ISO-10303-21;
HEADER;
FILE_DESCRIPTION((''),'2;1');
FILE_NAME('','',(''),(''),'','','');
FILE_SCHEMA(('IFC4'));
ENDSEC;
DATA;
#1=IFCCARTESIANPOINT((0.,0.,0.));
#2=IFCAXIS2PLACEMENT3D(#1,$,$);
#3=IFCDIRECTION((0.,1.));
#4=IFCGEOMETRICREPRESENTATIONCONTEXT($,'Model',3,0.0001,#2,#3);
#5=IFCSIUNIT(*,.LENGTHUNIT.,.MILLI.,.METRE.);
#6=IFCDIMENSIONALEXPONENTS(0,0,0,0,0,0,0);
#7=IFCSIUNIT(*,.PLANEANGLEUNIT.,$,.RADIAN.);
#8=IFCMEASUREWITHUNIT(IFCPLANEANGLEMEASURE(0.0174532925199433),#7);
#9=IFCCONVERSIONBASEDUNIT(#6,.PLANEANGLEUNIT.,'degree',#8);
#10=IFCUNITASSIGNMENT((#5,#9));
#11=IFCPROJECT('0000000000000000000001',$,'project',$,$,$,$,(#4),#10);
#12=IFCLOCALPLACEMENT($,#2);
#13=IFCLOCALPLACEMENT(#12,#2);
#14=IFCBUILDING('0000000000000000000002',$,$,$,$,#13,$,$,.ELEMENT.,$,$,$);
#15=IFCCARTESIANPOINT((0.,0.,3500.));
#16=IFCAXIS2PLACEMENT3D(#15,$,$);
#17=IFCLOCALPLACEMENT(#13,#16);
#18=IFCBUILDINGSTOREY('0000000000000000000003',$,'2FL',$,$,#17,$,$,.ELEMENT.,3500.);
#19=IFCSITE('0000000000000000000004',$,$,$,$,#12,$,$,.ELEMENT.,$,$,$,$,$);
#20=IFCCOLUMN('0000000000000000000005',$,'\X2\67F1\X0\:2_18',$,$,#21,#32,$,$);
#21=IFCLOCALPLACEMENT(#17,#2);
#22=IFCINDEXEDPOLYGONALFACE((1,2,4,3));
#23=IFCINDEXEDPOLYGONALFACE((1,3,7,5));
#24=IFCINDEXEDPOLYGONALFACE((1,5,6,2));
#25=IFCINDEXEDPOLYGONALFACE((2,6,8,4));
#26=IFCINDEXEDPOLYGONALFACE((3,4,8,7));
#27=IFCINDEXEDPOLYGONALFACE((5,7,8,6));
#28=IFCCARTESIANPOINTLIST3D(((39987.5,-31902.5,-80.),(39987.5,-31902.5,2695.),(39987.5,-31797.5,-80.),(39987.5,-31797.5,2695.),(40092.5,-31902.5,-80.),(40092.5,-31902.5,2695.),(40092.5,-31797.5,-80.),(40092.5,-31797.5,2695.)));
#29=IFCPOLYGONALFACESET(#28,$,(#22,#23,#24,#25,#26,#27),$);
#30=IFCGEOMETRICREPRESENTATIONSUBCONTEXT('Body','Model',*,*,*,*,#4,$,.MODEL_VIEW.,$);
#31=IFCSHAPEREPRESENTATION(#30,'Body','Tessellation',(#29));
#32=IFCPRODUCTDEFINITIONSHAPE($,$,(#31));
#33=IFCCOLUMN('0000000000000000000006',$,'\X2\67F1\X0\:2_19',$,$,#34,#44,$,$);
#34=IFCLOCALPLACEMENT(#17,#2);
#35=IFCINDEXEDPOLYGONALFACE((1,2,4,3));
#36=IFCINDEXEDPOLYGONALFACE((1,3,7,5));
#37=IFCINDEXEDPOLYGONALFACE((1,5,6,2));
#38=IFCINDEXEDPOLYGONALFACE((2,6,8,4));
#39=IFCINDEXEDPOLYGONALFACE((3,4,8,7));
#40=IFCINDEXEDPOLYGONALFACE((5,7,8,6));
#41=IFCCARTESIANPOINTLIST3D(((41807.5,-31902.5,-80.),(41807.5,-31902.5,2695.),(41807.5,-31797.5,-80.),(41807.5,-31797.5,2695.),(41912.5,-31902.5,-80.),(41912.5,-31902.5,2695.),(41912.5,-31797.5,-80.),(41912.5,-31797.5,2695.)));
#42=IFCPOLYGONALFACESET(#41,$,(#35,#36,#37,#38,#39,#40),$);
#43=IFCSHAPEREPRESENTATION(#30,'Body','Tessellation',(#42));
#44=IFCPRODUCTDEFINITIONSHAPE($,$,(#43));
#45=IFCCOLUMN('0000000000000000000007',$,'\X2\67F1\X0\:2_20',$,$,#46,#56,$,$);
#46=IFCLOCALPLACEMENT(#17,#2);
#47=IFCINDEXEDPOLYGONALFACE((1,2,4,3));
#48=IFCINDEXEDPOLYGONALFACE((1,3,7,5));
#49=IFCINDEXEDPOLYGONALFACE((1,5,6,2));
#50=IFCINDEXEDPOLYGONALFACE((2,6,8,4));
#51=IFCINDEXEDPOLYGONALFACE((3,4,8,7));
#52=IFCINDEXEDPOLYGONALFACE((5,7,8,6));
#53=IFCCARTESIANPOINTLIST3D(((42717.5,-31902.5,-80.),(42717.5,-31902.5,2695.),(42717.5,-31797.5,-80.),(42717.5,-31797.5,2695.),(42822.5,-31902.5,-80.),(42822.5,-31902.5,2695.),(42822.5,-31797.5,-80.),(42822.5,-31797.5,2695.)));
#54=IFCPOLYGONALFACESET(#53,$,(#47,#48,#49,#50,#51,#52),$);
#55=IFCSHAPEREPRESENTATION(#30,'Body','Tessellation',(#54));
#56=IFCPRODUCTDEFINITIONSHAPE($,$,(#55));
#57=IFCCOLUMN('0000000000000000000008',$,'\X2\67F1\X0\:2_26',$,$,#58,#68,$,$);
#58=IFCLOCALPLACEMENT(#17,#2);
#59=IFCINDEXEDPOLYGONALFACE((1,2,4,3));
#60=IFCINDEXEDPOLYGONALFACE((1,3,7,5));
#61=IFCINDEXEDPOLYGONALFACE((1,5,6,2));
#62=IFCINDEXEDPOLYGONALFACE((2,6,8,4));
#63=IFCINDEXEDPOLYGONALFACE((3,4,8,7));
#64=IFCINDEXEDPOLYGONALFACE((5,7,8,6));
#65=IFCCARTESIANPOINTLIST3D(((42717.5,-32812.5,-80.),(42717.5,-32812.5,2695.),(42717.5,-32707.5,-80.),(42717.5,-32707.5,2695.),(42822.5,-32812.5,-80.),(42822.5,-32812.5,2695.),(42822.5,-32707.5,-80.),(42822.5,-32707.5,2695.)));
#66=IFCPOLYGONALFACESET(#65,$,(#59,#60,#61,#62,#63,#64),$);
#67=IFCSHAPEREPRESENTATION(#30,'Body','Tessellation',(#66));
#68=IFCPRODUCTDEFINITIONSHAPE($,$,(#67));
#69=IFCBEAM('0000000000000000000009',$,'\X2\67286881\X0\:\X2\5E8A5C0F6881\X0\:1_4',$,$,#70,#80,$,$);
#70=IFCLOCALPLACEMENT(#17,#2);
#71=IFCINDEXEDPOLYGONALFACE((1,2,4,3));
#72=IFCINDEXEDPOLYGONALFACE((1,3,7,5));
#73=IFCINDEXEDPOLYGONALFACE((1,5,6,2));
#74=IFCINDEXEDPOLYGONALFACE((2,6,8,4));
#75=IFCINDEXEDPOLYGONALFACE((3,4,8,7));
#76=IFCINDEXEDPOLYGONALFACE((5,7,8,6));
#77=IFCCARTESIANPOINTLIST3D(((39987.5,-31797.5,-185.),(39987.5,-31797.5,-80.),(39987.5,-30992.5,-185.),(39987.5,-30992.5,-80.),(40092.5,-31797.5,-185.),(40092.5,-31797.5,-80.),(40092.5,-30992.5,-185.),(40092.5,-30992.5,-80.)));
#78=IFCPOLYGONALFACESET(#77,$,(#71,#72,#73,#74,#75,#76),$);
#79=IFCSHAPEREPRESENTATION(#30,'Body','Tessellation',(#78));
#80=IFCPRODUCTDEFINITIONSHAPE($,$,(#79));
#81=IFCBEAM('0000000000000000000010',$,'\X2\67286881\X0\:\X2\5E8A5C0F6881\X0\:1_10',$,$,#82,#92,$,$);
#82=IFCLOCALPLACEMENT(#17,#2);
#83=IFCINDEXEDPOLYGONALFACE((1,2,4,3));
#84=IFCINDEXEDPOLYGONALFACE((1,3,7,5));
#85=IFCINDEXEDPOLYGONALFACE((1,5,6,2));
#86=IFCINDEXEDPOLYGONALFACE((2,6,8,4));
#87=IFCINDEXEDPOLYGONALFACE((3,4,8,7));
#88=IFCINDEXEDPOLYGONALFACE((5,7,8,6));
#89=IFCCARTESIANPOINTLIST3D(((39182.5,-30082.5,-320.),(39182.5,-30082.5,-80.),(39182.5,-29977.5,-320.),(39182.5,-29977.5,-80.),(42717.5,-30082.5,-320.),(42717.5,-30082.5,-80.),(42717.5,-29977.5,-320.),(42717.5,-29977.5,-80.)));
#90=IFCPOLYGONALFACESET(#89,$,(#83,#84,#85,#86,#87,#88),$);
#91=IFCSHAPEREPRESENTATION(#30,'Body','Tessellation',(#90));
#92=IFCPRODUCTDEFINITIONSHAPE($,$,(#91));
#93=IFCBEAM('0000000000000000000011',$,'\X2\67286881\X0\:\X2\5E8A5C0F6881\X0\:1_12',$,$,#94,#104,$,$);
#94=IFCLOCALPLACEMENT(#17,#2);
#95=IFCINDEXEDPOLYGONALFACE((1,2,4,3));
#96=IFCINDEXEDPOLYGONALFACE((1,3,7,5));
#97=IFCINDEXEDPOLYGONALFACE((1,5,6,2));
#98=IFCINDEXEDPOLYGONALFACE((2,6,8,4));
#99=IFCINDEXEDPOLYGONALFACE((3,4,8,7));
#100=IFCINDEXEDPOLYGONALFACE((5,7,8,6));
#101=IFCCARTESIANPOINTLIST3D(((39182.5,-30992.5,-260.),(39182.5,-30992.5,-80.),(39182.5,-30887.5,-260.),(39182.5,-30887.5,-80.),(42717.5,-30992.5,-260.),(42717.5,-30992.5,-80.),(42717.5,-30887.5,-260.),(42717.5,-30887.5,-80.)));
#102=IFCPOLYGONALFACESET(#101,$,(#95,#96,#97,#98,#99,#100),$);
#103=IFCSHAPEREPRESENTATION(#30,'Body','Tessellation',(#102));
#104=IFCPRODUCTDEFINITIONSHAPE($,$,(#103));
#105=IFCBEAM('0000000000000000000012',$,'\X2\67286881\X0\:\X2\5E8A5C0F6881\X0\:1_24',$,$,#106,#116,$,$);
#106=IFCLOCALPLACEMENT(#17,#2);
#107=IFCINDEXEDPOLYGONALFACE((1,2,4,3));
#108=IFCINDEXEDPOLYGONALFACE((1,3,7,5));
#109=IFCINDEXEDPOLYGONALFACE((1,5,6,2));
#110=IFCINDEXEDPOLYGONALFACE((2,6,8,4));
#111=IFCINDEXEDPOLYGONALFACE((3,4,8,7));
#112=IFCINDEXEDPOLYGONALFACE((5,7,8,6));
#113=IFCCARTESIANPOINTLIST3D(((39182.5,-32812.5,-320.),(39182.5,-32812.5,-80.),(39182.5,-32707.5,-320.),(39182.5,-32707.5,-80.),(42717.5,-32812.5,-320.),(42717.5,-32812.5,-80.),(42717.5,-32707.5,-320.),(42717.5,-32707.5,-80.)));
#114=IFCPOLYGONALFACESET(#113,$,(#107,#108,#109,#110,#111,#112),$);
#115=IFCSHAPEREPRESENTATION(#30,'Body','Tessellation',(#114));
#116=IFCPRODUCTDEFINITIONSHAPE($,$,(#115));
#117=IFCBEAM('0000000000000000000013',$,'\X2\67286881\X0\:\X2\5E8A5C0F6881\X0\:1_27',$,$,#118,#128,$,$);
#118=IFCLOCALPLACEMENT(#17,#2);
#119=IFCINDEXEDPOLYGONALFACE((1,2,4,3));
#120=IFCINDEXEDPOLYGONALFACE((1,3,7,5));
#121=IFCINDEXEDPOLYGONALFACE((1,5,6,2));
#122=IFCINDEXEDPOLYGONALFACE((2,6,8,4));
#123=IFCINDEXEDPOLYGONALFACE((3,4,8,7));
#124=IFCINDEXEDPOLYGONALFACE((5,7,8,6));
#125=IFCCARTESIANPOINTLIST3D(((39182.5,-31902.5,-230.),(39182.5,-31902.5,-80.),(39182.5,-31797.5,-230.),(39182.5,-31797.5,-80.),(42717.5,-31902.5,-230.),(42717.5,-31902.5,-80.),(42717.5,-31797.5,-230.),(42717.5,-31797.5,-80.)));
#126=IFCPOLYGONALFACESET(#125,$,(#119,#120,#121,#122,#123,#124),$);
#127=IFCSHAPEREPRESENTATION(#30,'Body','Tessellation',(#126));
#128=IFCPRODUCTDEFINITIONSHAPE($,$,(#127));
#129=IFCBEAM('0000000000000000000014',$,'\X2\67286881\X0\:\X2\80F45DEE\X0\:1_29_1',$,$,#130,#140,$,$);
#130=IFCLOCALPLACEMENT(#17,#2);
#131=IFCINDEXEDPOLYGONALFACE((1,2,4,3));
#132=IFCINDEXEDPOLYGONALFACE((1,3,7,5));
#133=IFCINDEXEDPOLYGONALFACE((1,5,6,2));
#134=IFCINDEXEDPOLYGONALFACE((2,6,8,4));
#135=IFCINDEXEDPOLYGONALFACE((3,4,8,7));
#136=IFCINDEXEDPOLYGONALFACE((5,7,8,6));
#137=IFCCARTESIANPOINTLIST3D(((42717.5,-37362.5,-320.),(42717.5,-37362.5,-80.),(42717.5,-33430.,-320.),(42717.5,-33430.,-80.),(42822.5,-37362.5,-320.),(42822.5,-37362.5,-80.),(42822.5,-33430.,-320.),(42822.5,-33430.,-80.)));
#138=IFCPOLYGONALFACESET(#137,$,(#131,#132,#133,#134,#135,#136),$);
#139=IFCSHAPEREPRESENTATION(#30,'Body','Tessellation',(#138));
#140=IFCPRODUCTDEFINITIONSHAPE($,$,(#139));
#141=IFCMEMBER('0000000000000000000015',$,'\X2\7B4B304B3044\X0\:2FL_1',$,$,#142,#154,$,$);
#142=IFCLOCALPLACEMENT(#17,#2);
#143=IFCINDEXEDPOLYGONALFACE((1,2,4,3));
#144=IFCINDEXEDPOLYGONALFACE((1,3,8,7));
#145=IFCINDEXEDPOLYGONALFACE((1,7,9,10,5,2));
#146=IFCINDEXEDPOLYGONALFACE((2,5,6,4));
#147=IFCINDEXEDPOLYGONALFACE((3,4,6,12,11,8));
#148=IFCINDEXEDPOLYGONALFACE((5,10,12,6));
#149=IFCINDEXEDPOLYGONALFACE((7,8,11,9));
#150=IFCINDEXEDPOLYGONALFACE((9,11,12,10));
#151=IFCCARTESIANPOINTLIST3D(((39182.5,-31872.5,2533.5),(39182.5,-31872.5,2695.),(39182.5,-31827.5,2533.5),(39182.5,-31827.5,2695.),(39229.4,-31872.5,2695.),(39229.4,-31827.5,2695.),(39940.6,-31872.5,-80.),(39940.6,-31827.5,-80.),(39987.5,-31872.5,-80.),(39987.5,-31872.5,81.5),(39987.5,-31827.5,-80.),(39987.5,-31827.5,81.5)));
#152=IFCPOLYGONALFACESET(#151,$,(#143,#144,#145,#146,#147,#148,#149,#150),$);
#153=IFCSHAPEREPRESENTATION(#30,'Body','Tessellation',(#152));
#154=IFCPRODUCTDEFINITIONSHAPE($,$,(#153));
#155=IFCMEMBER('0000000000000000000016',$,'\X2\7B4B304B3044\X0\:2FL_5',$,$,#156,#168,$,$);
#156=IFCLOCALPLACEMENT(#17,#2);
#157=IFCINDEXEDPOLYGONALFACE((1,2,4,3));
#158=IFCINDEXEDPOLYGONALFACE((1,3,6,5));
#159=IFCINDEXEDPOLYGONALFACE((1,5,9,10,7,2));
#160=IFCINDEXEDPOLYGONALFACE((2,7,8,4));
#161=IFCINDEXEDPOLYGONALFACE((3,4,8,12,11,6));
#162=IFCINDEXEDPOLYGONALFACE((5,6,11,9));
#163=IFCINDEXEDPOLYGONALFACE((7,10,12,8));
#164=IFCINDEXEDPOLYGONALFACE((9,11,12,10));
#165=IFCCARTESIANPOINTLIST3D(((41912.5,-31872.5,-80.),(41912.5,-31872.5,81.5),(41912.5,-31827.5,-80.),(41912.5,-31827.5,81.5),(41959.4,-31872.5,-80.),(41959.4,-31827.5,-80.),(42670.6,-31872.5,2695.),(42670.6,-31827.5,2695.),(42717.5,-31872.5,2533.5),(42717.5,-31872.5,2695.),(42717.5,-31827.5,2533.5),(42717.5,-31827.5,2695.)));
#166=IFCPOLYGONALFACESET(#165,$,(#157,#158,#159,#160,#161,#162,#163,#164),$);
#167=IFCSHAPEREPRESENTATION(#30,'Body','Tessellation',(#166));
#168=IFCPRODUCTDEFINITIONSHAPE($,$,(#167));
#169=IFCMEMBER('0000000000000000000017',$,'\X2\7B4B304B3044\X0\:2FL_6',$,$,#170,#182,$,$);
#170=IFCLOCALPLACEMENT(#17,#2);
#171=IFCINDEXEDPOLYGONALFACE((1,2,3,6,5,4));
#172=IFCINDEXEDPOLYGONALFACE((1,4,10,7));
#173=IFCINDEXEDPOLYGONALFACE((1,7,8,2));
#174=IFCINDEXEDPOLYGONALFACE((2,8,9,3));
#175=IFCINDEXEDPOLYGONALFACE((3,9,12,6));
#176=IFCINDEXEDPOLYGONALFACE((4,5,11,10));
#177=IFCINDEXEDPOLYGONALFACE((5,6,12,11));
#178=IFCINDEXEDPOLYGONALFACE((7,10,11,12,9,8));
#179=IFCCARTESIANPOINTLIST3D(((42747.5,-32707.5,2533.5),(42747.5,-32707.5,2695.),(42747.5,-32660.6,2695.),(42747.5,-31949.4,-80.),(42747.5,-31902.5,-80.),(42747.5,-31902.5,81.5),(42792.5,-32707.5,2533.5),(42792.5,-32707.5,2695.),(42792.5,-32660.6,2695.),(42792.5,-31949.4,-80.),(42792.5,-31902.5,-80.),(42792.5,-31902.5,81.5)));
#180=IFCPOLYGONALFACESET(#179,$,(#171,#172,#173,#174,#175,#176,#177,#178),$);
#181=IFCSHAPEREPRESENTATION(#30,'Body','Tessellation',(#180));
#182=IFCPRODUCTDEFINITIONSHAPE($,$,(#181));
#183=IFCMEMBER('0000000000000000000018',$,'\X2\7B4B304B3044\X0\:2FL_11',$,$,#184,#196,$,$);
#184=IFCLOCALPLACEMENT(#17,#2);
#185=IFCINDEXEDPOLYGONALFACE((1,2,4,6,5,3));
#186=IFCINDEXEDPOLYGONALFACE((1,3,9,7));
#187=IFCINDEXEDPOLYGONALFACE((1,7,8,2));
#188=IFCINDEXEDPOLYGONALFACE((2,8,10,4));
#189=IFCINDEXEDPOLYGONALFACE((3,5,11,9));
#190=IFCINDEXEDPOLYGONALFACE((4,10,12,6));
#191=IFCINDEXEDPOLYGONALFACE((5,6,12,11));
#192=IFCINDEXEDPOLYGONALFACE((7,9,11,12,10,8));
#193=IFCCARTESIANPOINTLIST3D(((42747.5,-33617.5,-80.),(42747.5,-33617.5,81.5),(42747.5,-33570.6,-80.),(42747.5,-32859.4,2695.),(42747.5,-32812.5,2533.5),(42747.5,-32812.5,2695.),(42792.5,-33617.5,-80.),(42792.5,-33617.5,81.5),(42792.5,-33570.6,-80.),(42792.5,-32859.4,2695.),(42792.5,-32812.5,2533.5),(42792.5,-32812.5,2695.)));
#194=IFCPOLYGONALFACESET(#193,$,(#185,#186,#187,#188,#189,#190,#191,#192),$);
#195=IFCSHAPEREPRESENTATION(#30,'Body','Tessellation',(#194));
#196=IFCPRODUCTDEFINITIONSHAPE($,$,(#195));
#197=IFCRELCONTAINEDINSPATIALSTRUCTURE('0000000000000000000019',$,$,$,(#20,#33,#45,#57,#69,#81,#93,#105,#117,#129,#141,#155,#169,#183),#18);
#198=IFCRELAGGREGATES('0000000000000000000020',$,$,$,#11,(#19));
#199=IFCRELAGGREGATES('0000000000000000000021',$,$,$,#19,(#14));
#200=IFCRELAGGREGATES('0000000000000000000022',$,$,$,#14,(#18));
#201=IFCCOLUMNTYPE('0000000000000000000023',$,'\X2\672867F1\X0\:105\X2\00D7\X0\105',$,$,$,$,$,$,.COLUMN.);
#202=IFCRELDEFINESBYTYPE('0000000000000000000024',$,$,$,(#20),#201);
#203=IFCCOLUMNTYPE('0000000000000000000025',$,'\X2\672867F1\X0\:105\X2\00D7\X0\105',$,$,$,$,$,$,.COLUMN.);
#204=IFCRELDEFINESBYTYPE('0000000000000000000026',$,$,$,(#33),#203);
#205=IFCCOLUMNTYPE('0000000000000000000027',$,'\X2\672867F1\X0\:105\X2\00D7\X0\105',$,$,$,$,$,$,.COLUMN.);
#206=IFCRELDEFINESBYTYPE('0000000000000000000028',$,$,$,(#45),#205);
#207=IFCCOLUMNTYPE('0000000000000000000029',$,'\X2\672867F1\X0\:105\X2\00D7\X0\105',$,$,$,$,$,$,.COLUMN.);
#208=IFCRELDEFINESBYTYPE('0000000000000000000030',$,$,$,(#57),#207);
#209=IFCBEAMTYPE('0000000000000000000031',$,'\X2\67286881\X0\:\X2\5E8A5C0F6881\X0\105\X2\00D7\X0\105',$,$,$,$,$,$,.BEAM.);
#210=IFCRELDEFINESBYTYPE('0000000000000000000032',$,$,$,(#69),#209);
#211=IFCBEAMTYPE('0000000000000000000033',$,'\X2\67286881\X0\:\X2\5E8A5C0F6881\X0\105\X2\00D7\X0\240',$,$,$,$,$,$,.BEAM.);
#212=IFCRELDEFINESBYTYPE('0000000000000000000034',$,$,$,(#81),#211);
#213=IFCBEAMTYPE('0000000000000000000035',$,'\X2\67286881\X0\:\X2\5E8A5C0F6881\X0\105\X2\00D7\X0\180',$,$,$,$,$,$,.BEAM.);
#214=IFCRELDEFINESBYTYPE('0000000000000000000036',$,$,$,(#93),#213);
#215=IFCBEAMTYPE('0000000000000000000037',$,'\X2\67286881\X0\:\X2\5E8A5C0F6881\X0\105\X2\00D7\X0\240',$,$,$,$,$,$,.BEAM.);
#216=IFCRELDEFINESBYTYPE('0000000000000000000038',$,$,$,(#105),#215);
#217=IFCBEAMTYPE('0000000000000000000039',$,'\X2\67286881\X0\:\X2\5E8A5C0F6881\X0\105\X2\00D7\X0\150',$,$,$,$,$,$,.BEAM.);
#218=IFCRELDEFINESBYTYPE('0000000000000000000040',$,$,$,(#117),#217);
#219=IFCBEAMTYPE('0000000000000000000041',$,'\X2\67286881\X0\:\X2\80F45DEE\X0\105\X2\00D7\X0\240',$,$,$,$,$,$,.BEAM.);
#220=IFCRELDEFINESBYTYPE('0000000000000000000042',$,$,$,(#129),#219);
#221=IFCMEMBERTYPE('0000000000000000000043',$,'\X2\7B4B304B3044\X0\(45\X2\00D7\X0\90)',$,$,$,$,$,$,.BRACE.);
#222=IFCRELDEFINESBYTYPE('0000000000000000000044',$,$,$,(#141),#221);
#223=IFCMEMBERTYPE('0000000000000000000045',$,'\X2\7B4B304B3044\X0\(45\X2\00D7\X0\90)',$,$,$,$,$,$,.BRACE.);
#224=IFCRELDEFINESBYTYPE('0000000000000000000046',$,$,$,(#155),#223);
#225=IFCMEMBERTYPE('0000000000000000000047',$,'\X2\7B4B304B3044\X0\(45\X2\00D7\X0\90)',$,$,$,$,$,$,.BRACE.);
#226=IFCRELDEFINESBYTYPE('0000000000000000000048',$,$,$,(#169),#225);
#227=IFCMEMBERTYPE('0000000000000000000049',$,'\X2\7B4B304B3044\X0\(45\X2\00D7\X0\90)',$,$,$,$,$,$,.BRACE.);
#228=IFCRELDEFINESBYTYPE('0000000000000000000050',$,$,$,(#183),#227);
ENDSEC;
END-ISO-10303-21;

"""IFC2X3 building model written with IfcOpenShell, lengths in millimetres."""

from ifc_helpers import new_model, entity, si_unit, converted_unit, direction, frame, origin, origin_with_axes, origin_2d, place, context, subcontext, project, spatial, polyline, rectangle, outline, extrude, type_object, element, save


model = new_model("IFC2X3")

# Units and contexts
model_context = context("Model", 3, precision=0.0001, world=origin(), true_north=direction((0.0, 1.0)))
body_context = subcontext(model_context, "Body", "Model", "MODEL_VIEW")
ifc_project = project(units=[si_unit("LENGTHUNIT", "METRE", prefix="MILLI"), converted_unit("PLANEANGLEUNIT", "degree", entity("IfcPlaneAngleMeasure", 0.0174532925199433), si_unit("PLANEANGLEUNIT", "RADIAN"), dimensions=[0, 0, 0, 0, 0, 0, 0])], contexts=[model_context])

# Site, building, storey
site_placement = place(None, origin())
site = spatial("IfcSite", under=ifc_project, at=site_placement, CompositionType="ELEMENT")
building_placement = place(site_placement, origin())
building = spatial("IfcBuilding", under=site, at=building_placement, CompositionType="ELEMENT")
storey_placement = place(building_placement, frame((0.0, 0.0, 3500.0)))
storey = spatial("IfcBuildingStorey", under=building, at=storey_placement, Name="2FL", CompositionType="ELEMENT", Elevation=3500.0)

# Columns
column_type_1 = type_object("IfcColumnType", Name="木柱:105×105", PredefinedType="COLUMN")
column_1_placement = place(storey_placement, frame((40040.0, -31850.0, -80.0)))
element("IfcColumn", 1, at=column_1_placement, inside=storey, type_object=column_type_1, Name="柱:2_18", context=body_context, shape_type="SweptSolid", body=[
    extrude(rectangle(XDim=105.0, YDim=105.0, at=origin_2d()), origin_with_axes(), (0.0, 0.0, 1.0), 2775.0),
])
column_type_2 = type_object("IfcColumnType", Name="木柱:105×105", PredefinedType="COLUMN")
column_2_placement = place(storey_placement, frame((41860.0, -31850.0, -80.0)))
element("IfcColumn", 2, at=column_2_placement, inside=storey, type_object=column_type_2, Name="柱:2_19", context=body_context, shape_type="SweptSolid", body=[
    extrude(rectangle(XDim=105.0, YDim=105.0, at=origin_2d()), origin_with_axes(), (0.0, 0.0, 1.0), 2775.0),
])
column_type_3 = type_object("IfcColumnType", Name="木柱:105×105", PredefinedType="COLUMN")
column_3_placement = place(storey_placement, frame((42770.0, -31850.0, -80.0)))
element("IfcColumn", 3, at=column_3_placement, inside=storey, type_object=column_type_3, Name="柱:2_20", context=body_context, shape_type="SweptSolid", body=[
    extrude(rectangle(XDim=105.0, YDim=105.0, at=origin_2d()), origin_with_axes(), (0.0, 0.0, 1.0), 2775.0),
])
column_type_4 = type_object("IfcColumnType", Name="木柱:105×105", PredefinedType="COLUMN")
column_4_placement = place(storey_placement, frame((42770.0, -32760.0, -80.0)))
element("IfcColumn", 4, at=column_4_placement, inside=storey, type_object=column_type_4, Name="柱:2_26", context=body_context, shape_type="SweptSolid", body=[
    extrude(rectangle(XDim=105.0, YDim=105.0, at=origin_2d()), origin_with_axes(), (0.0, 0.0, 1.0), 2775.0),
])

# Beams
beam_type_1 = type_object("IfcBeamType", Name="木梁:床小梁105×105", PredefinedType="BEAM")
beam_1_placement = place(storey_placement, frame((40040.0, -30992.5, -132.5), z_axis=(0.0, -1.0, 0.0), x_axis=(1.0, 0.0, 0.0)))
element("IfcBeam", 5, at=beam_1_placement, inside=storey, type_object=beam_type_1, Name="木梁:床小梁:1_4", context=body_context, shape_type="SweptSolid", body=[
    extrude(rectangle(XDim=105.0, YDim=105.0, at=origin_2d()), origin_with_axes(), (0.0, 0.0, 1.0), 805.0),
])
beam_type_2 = type_object("IfcBeamType", Name="木梁:床小梁105×240", PredefinedType="BEAM")
beam_2_placement = place(storey_placement, frame((39182.5, -30030.0, -200.0), z_axis=(1.0, 0.0, 0.0), x_axis=(0.0, 1.0, 0.0)))
element("IfcBeam", 6, at=beam_2_placement, inside=storey, type_object=beam_type_2, Name="木梁:床小梁:1_10", context=body_context, shape_type="SweptSolid", body=[
    extrude(rectangle(XDim=105.0, YDim=240.0, at=origin_2d()), origin_with_axes(), (0.0, 0.0, 1.0), 3535.0),
])
beam_type_3 = type_object("IfcBeamType", Name="木梁:床小梁105×180", PredefinedType="BEAM")
beam_3_placement = place(storey_placement, frame((39182.5, -30940.0, -170.0), z_axis=(1.0, 0.0, 0.0), x_axis=(0.0, 1.0, 0.0)))
element("IfcBeam", 7, at=beam_3_placement, inside=storey, type_object=beam_type_3, Name="木梁:床小梁:1_12", context=body_context, shape_type="SweptSolid", body=[
    extrude(rectangle(XDim=105.0, YDim=180.0, at=origin_2d()), origin_with_axes(), (0.0, 0.0, 1.0), 3535.0),
])
beam_type_4 = type_object("IfcBeamType", Name="木梁:床小梁105×240", PredefinedType="BEAM")
beam_4_placement = place(storey_placement, frame((39182.5, -32760.0, -200.0), z_axis=(1.0, 0.0, 0.0), x_axis=(0.0, 1.0, 0.0)))
element("IfcBeam", 8, at=beam_4_placement, inside=storey, type_object=beam_type_4, Name="木梁:床小梁:1_24", context=body_context, shape_type="SweptSolid", body=[
    extrude(rectangle(XDim=105.0, YDim=240.0, at=origin_2d()), origin_with_axes(), (0.0, 0.0, 1.0), 3535.0),
])
beam_type_5 = type_object("IfcBeamType", Name="木梁:床小梁105×150", PredefinedType="BEAM")
beam_5_placement = place(storey_placement, frame((39182.5, -31850.0, -155.0), z_axis=(1.0, 0.0, 0.0), x_axis=(0.0, 1.0, 0.0)))
element("IfcBeam", 9, at=beam_5_placement, inside=storey, type_object=beam_type_5, Name="木梁:床小梁:1_27", context=body_context, shape_type="SweptSolid", body=[
    extrude(rectangle(XDim=105.0, YDim=150.0, at=origin_2d()), origin_with_axes(), (0.0, 0.0, 1.0), 3535.0),
])
beam_type_6 = type_object("IfcBeamType", Name="木梁:胴差105×240", PredefinedType="BEAM")
beam_6_placement = place(storey_placement, frame((42770.0, -33430.0, -200.0), z_axis=(0.0, -1.0, 0.0), x_axis=(1.0, 0.0, 0.0)))
element("IfcBeam", 10, at=beam_6_placement, inside=storey, type_object=beam_type_6, Name="木梁:胴差:1_29_1", context=body_context, shape_type="SweptSolid", body=[
    extrude(rectangle(XDim=105.0, YDim=240.0, at=origin_2d()), origin_with_axes(), (0.0, 0.0, 1.0), 3932.5),
])

# Members
member_type_1 = type_object("IfcMemberType", Name="筋かい(45×90)", PredefinedType="BRACE")
member_1_placement = place(storey_placement, frame((39987.5, -31850.0, -80.0), z_axis=(-0.278604, 0.0, 0.960406), x_axis=(0.960406, 0.0, 0.278604)))
element("IfcMember", 11, at=member_1_placement, inside=storey, type_object=member_type_1, Name="筋かい:2FL_1", context=body_context, shape_type="SweptSolid", body=[
    extrude(outline(polyline([(0.0, 0.0), (13.1, -45.0), (2734.3, -45.0), (2889.4, 0.0), (2876.3, 45.0), (155.1, 45.0), (0.0, 0.0)])), frame((0.0, -22.5, 0.0), z_axis=(0.0, 1.0, 0.0), x_axis=(0.0, 0.0, 1.0)), (0.0, 0.0, 1.0), 45.0),
])
member_type_2 = type_object("IfcMemberType", Name="筋かい(45×90)", PredefinedType="BRACE")
member_2_placement = place(storey_placement, frame((41912.5, -31850.0, -80.0), z_axis=(0.278604, 0.0, 0.960406), x_axis=(-0.960406, 0.0, 0.278604)))
element("IfcMember", 12, at=member_2_placement, inside=storey, type_object=member_type_2, Name="筋かい:2FL_5", context=body_context, shape_type="SweptSolid", body=[
    extrude(outline(polyline([(0.0, 0.0), (13.1, -45.0), (2734.3, -45.0), (2889.4, 0.0), (2876.3, 45.0), (155.1, 45.0), (0.0, 0.0)])), frame((0.0, -22.5, 0.0), z_axis=(0.0, 1.0, 0.0), x_axis=(0.0, 0.0, 1.0)), (0.0, 0.0, 1.0), 45.0),
])
member_type_3 = type_object("IfcMemberType", Name="筋かい(45×90)", PredefinedType="BRACE")
member_3_placement = place(storey_placement, frame((42770.0, -31902.5, -80.0), z_axis=(0.0, -0.278604, 0.960406), x_axis=(0.0, 0.960406, 0.278604)))
element("IfcMember", 13, at=member_3_placement, inside=storey, type_object=member_type_3, Name="筋かい:2FL_6", context=body_context, shape_type="SweptSolid", body=[
    extrude(outline(polyline([(0.0, 0.0), (13.1, -45.0), (2734.3, -45.0), (2889.4, 0.0), (2876.3, 45.0), (155.1, 45.0), (0.0, 0.0)])), frame((0.0, -22.5, 0.0), z_axis=(0.0, 1.0, 0.0), x_axis=(0.0, 0.0, 1.0)), (0.0, 0.0, 1.0), 45.0),
])
member_type_4 = type_object("IfcMemberType", Name="筋かい(45×90)", PredefinedType="BRACE")
member_4_placement = place(storey_placement, frame((42770.0, -33617.5, -80.0), z_axis=(0.0, 0.278604, 0.960406), x_axis=(0.0, -0.960406, 0.278604)))
element("IfcMember", 14, at=member_4_placement, inside=storey, type_object=member_type_4, Name="筋かい:2FL_11", context=body_context, shape_type="SweptSolid", body=[
    extrude(outline(polyline([(0.0, 0.0), (13.1, -45.0), (2734.3, -45.0), (2889.4, 0.0), (2876.3, 45.0), (155.1, 45.0), (0.0, 0.0)])), frame((0.0, -22.5, 0.0), z_axis=(0.0, 1.0, 0.0), x_axis=(0.0, 0.0, 1.0)), (0.0, 0.0, 1.0), 45.0),
])

save(model, "model.ifc")
